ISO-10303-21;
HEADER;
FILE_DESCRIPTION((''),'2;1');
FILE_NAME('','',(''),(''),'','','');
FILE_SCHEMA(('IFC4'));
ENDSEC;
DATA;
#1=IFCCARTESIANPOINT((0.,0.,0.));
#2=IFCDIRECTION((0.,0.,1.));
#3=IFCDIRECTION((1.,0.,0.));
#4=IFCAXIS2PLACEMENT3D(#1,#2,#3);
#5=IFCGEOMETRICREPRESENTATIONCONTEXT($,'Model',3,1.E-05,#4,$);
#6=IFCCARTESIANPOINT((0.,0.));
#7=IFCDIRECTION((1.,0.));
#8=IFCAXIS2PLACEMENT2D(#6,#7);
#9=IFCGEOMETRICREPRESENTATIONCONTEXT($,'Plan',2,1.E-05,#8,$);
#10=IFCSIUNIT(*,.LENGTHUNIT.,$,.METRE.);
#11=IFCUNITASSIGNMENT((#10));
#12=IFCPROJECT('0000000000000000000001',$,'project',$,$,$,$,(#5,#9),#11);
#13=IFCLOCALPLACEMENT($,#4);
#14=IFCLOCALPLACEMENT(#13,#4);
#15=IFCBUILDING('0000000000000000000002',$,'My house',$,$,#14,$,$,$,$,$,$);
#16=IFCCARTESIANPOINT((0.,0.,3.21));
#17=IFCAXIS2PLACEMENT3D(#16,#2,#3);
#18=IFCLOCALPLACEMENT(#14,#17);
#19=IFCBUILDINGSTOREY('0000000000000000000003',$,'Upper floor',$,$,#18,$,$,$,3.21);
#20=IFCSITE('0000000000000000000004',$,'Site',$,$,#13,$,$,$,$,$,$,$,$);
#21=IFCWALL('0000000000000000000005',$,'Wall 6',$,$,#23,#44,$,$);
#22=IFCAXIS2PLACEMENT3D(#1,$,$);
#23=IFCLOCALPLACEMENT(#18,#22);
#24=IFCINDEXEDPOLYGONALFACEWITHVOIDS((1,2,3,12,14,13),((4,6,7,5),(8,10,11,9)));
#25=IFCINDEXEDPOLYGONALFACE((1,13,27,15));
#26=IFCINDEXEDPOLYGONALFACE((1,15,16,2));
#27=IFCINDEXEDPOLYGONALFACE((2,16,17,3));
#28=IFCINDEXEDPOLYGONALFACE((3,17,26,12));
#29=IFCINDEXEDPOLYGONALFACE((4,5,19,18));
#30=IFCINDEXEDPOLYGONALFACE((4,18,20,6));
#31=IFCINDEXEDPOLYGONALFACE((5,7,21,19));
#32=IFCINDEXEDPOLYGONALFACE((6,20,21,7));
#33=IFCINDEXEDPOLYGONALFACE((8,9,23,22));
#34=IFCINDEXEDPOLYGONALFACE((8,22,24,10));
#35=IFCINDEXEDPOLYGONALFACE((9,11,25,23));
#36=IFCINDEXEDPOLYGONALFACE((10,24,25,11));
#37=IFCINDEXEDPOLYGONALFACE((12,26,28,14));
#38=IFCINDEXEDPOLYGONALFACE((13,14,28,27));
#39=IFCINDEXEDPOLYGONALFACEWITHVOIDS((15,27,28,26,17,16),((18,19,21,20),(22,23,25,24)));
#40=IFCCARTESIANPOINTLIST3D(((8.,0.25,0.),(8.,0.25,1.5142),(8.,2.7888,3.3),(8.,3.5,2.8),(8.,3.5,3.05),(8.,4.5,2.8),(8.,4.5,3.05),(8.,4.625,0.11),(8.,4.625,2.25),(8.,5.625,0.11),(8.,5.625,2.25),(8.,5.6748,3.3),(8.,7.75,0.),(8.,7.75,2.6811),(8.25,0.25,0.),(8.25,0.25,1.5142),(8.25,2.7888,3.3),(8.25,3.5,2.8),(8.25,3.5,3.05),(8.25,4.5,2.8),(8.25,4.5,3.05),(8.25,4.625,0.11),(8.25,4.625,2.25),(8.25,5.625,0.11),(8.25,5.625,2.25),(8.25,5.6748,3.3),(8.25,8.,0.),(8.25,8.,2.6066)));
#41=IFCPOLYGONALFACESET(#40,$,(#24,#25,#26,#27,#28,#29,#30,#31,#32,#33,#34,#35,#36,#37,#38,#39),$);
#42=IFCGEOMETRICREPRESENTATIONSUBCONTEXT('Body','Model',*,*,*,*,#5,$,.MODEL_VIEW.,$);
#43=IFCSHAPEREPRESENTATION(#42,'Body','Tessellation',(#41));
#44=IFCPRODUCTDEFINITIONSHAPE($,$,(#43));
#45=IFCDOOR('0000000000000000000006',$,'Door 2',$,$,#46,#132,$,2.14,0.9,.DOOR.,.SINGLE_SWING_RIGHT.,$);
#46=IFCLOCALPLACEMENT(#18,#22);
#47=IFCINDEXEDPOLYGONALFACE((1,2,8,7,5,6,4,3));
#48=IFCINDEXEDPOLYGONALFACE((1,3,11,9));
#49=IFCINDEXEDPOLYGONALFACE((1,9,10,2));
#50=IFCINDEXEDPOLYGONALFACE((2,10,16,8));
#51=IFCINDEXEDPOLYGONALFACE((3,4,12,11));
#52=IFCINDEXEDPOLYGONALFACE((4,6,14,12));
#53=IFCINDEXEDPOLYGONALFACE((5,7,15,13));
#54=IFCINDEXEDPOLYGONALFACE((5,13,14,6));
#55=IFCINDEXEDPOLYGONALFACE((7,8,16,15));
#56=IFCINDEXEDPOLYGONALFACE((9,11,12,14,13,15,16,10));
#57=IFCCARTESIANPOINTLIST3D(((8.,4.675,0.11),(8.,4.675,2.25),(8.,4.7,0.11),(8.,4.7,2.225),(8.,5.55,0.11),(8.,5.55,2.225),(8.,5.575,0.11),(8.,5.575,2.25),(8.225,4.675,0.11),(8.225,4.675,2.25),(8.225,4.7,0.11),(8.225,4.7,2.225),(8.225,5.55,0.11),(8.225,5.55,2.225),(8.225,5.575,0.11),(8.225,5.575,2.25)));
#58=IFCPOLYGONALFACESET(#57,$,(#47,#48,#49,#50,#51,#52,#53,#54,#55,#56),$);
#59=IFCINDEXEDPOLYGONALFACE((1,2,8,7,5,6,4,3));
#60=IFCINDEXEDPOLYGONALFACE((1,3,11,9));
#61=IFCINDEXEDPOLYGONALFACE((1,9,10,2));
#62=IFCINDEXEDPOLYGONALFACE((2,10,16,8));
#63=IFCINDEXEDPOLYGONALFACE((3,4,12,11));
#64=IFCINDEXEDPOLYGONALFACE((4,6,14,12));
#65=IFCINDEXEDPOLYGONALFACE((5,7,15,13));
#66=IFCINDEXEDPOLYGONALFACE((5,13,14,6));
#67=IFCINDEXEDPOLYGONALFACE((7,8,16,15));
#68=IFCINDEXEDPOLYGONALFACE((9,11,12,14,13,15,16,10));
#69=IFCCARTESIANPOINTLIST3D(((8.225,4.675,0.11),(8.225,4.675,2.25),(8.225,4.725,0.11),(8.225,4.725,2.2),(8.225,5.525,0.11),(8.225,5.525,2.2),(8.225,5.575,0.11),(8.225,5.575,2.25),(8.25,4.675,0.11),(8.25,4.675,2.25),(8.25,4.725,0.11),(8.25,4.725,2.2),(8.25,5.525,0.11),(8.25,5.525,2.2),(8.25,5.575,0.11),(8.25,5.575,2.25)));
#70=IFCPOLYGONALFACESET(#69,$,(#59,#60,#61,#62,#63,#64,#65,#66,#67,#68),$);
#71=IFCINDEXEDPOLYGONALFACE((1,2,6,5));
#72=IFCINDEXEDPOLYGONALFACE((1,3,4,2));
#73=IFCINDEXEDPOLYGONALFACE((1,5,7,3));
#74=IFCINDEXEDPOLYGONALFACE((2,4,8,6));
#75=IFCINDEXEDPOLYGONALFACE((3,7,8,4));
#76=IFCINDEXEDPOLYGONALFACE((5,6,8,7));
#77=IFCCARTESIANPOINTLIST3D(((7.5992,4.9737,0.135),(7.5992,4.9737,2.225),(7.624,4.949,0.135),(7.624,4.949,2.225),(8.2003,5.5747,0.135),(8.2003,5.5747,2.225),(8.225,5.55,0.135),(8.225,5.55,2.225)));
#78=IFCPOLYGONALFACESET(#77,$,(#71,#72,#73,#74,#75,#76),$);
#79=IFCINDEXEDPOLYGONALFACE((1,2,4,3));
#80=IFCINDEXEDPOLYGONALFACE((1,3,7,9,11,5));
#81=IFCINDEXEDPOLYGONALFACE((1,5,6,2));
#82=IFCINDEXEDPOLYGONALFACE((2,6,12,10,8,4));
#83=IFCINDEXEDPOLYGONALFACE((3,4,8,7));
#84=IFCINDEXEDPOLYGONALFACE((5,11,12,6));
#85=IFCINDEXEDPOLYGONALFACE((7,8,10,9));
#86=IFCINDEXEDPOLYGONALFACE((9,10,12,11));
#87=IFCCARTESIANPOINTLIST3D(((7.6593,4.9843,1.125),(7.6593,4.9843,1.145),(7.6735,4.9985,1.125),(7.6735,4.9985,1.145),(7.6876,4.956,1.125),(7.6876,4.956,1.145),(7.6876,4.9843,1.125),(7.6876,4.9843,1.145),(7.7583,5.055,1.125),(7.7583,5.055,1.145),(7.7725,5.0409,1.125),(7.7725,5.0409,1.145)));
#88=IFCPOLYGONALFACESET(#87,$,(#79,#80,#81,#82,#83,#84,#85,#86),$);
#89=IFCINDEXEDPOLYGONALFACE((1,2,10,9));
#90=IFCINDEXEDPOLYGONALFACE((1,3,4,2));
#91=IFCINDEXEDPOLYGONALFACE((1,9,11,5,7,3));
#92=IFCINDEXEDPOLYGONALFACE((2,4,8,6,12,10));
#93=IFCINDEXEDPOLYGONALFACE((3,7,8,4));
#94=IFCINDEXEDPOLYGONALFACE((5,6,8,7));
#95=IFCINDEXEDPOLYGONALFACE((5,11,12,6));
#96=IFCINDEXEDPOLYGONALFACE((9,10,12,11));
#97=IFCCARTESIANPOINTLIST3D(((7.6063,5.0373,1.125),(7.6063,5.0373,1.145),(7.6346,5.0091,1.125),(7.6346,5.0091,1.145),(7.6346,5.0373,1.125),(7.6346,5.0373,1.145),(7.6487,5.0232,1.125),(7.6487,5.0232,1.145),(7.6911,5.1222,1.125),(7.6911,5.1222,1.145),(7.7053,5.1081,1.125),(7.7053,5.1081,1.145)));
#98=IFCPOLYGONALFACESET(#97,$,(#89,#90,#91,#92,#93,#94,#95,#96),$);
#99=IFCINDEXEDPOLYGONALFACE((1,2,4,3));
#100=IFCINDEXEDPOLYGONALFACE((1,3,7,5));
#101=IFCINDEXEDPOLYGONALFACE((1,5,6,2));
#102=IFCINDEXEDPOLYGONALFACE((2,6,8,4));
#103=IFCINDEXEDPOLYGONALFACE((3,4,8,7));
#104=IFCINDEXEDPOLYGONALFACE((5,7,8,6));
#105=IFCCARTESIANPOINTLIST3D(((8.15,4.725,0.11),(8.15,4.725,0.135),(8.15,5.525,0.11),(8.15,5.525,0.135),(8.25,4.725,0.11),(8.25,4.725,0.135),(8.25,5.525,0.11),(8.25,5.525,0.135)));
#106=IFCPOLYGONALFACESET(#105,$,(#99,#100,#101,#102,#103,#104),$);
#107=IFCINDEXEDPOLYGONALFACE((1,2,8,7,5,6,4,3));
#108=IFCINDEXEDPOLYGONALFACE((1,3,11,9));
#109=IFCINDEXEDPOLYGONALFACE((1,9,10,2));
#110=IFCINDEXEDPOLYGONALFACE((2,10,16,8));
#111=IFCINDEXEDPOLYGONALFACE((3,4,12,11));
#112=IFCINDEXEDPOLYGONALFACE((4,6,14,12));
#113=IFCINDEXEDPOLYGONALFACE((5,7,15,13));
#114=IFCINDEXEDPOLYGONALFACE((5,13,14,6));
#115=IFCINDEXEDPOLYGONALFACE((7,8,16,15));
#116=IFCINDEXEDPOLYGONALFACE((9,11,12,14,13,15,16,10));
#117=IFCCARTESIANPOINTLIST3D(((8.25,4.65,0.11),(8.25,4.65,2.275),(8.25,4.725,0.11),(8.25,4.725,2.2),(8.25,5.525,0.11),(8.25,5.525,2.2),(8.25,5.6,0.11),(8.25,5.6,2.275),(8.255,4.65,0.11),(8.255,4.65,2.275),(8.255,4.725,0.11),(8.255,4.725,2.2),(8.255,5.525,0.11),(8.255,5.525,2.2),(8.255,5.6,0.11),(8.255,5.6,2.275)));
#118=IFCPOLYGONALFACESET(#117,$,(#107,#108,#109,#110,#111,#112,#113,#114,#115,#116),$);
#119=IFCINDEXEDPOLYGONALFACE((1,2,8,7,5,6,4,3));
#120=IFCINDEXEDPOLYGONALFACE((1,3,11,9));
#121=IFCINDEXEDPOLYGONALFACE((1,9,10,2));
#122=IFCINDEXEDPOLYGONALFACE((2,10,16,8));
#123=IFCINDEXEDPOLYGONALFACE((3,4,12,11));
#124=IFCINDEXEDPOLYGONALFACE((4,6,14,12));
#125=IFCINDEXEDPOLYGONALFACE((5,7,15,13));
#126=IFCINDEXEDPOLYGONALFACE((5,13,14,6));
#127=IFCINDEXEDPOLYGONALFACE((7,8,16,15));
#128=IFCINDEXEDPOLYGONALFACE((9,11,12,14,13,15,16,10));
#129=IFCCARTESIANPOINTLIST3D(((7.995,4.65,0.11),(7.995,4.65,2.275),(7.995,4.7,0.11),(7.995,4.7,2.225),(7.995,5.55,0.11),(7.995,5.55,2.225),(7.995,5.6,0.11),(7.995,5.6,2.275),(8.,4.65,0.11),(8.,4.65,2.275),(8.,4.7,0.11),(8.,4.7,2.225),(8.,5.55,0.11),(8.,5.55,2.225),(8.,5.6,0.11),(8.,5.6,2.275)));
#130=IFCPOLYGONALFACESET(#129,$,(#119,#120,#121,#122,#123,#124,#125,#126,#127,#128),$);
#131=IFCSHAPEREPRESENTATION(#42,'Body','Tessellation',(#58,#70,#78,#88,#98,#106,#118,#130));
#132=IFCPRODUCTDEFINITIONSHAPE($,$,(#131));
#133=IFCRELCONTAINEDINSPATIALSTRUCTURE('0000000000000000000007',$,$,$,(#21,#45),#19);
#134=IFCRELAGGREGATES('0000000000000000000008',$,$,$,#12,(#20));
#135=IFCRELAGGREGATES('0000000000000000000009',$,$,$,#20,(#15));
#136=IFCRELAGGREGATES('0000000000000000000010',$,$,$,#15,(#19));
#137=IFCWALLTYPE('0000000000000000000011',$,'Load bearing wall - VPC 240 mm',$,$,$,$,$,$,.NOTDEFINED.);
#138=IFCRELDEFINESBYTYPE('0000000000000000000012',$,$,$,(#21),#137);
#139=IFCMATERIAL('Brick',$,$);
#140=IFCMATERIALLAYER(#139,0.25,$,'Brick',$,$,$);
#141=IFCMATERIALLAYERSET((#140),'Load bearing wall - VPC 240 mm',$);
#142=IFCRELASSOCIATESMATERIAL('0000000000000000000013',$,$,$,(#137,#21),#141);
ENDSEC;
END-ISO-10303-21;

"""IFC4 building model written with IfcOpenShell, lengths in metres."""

from ifc_helpers import new_model, entity, si_unit, frame, origin_with_axes, origin_2d_with_axis, place, context, subcontext, project, spatial, line, indexed_curve, outline, extrude, clip, halfspace, shape, material, layer, layer_set, layer_usage, type_object, element, fill, save


model = new_model("IFC4")

# Units and contexts
model_context = context("Model", 3, precision=1e-05, world=origin_with_axes())
plan_context = context("Plan", 2, precision=1e-05, world=origin_2d_with_axis())
body_context_1 = subcontext(model_context, "Body", "Model", "MODEL_VIEW")
body_context_2 = subcontext(plan_context, "Body", "Plan", "PLAN_VIEW")
ifc_project = project(units=[si_unit("LENGTHUNIT", "METRE")], contexts=[model_context, plan_context])

# Site, building, storey
site_placement = place(None, origin_with_axes())
site = spatial("IfcSite", under=ifc_project, at=site_placement, Name="Site")
building_placement = place(site_placement, origin_with_axes())
building = spatial("IfcBuilding", under=site, at=building_placement, Name="My house")
storey_placement = place(building_placement, frame((0.0, 0.0, 3.21), z_axis=(0.0, 0.0, 1.0), x_axis=(1.0, 0.0, 0.0)))
storey = spatial("IfcBuildingStorey", under=building, at=storey_placement, Name="Upper floor", Elevation=3.21)

# Shared definitions
ifc_material_1 = material(Name="Brick")
ifc_layer_1 = layer(ifc_material_1, 0.25, Name="Brick")
ifc_layer_set_1 = layer_set([ifc_layer_1], Name="Load bearing wall - VPC 240 mm")
wall_type_1 = type_object("IfcWallType", Name="Load bearing wall - VPC 240 mm", PredefinedType="NOTDEFINED", material=ifc_layer_set_1)

# Wall, openings, door
ifc_layer_usage_1 = layer_usage(ifc_layer_set_1, "AXIS2", "NEGATIVE", 0.25)
wall_1_placement = place(storey_placement, frame((8.25, 0.0, 0.0), z_axis=(0.0, 0.0, 1.0), x_axis=(0.0, 1.0, 0.0)))
wall_1 = element("IfcWall", 1, at=wall_1_placement, inside=storey, type_object=wall_type_1, material=ifc_layer_usage_1, Name="Wall 6", context=body_context_1, shape_type="Clipping", body=[
    clip(clip(clip(extrude(outline(indexed_curve([(0.25, 0.0), (0.25, 0.25), (7.75, 0.25), (8.0, 0.0)], segments=[line(1, 2, 3, 4, 1)])), origin_with_axes(), (0.0, 0.0, 1.0), 4.0), halfspace(frame((0.045, 8.25, 1.37), z_axis=(-0.575329, 0.0, 0.817922), x_axis=(0.0, 1.0, 0.0)), False)), halfspace(frame((7.955, 8.25, 2.62), z_axis=(0.28578, 0.0, 0.958295), x_axis=(0.0, -1.0, 0.0)), False)), halfspace(frame((3.13, 8.25, 3.3), z_axis=(0.0, 0.0, 1.0), x_axis=(-1.0, 0.0, 0.0)), False)),
])
opening_1_placement = place(wall_1_placement, frame((3.5, 0.0, 2.8), z_axis=(0.0, 0.0, 1.0), x_axis=(1.0, 0.0, 0.0)))
element("IfcOpeningElement", 2, at=opening_1_placement, cuts=wall_1, PredefinedType="OPENING", context=body_context_1, shape_type="SweptSolid", body=[
    extrude(outline(indexed_curve([(0.0, 0.0), (0.0, 0.35), (1.0, 0.35), (1.0, 0.0), (0.0, 0.0)], self_intersect=False)), frame((0.0, -0.05, 0.0), z_axis=(0.0, 0.0, 1.0), x_axis=(1.0, 0.0, 0.0)), (0.0, 0.0, 1.0), 0.25),
])
opening_2_placement = place(wall_1_placement, frame((4.625, 0.0, 0.11), z_axis=(0.0, 0.0, 1.0), x_axis=(1.0, 0.0, 0.0)))
opening_2 = element("IfcOpeningElement", 3, at=opening_2_placement, cuts=wall_1, PredefinedType="OPENING", context=body_context_1, shape_type="SweptSolid", body=[
    extrude(outline(indexed_curve([(0.0, 0.0), (0.0, 0.35), (1.0, 0.35), (1.0, 0.0), (0.0, 0.0)], self_intersect=False)), frame((0.0, -0.05, 0.0), z_axis=(0.0, 0.0, 1.0), x_axis=(1.0, 0.0, 0.0)), (0.0, 0.0, 1.0), 2.14),
])
door_1_placement = place(opening_2_placement, frame((0.05, 0.0, 0.0), z_axis=(0.0, 0.0, 1.0), x_axis=(1.0, 0.0, 0.0)))
door_1 = element("IfcDoor", 4, at=door_1_placement, inside=storey, Name="Door 2", OperationType="SINGLE_SWING_RIGHT", OverallHeight=2.14, OverallWidth=0.9, PredefinedType="DOOR", shapes=[
    shape(body_context_1, "Body", "SweptSolid", [extrude(outline(indexed_curve([(0.0, 0.0), (0.0, 2.14), (0.9, 2.14), (0.9, 0.0), (0.875, 0.0), (0.875, 2.115), (0.025, 2.115), (0.025, 0.0)], segments=[line(1, 2, 3, 4, 5, 6, 7, 8, 1)])), frame((0.0, 0.025, 0.0), z_axis=(0.0, -1.0, 0.0), x_axis=(1.0, 0.0, 0.0)), (0.0, 0.0, -1.0), 0.225), extrude(outline(indexed_curve([(0.0, 0.0), (0.0, 2.14), (0.9, 2.14), (0.9, 0.0), (0.85, 0.0), (0.85, 2.09), (0.05, 2.09), (0.05, 0.0)], segments=[line(1, 2, 3, 4, 5, 6, 7, 8, 1)])), frame((0.0, 0.0, 0.0), z_axis=(0.0, -1.0, 0.0), x_axis=(1.0, 0.0, 0.0)), (0.0, 0.0, -1.0), 0.025), extrude(outline(indexed_curve([(0.0, 0.0), (0.85, 0.0), (0.85, 0.035), (0.0, 0.035)], segments=[line(1, 2, 3, 4, 1)])), frame((0.274, 0.626, 0.025), z_axis=(0.0, 0.0, 1.0), x_axis=(0.707107, -0.707107, 0.0)), (0.0, 0.0, 1.0), 2.09), extrude(outline(indexed_curve([(0.0, 0.0), (0.0, -0.04), (0.12, -0.04), (0.12, -0.02), (0.02, -0.02), (0.02, 0.0)], segments=[line(1, 2, 3, 4, 5, 6, 1)])), frame((0.3093, 0.5907, 1.015), z_axis=(0.0, 0.0, 1.0), x_axis=(0.707107, -0.707107, 0.0)), (0.0, 0.0, 1.0), 0.02), extrude(outline(indexed_curve([(0.0, 0.0), (0.0, 0.04), (0.12, 0.04), (0.12, 0.02), (0.02, 0.02), (0.02, 0.0)], segments=[line(1, 2, 3, 4, 5, 6, 1)])), frame((0.3341, 0.6154, 1.015), z_axis=(0.0, 0.0, 1.0), x_axis=(0.707107, -0.707107, 0.0)), (0.0, 0.0, 1.0), 0.02), extrude(outline(indexed_curve([(0.0, 0.0), (0.8, 0.0), (0.8, 0.1), (0.0, 0.1)], segments=[line(1, 2, 3, 4, 1)])), frame((0.05, 0.0, 0.0), z_axis=(0.0, 0.0, 1.0), x_axis=(1.0, 0.0, 0.0)), (0.0, 0.0, 1.0), 0.025), extrude(outline(indexed_curve([(0.0, 0.0), (0.0, 2.165), (0.95, 2.165), (0.95, 0.0), (0.875, 0.0), (0.875, 2.09), (0.075, 2.09), (0.075, 0.0)], segments=[line(1, 2, 3, 4, 5, 6, 7, 8, 1)])), frame((-0.025, -0.005, 0.0), z_axis=(0.0, -1.0, 0.0), x_axis=(1.0, 0.0, 0.0)), (0.0, 0.0, -1.0), 0.005), extrude(outline(indexed_curve([(0.0, 0.0), (0.0, 2.165), (0.95, 2.165), (0.95, 0.0), (0.9, 0.0), (0.9, 2.115), (0.05, 2.115), (0.05, 0.0)], segments=[line(1, 2, 3, 4, 5, 6, 7, 8, 1)])), frame((-0.025, 0.25, 0.0), z_axis=(0.0, -1.0, 0.0), x_axis=(1.0, 0.0, 0.0)), (0.0, 0.0, -1.0), 0.005)]),
    shape(body_context_2, "Body", "Curve2D", [entity("IfcIndexedPolyCurve", entity("IfcCartesianPointList2D", [[0.0, 0.0], [0.0, 0.25], [0.025, 0.25], [0.025, 0.025], [0.05, 0.025], [0.05, 0.0]]), [entity("IfcLineIndex", [1, 2, 3, 4, 5, 6, 1])]), entity("IfcIndexedPolyCurve", entity("IfcCartesianPointList2D", [[0.9, 0.0], [0.9, 0.25], [0.875, 0.25], [0.875, 0.025], [0.85, 0.025], [0.85, 0.0]]), [entity("IfcLineIndex", [1, 2, 3, 4, 5, 6, 1])]), entity("IfcTrimmedCurve", entity("IfcEllipse", entity("IfcAxis2Placement2D", entity("IfcCartesianPoint", [0.84, 0.25]), entity("IfcDirection", [1.0, 0.0])), 0.815, 0.85), [entity("IfcCartesianPoint", [0.84, 1.1])], [entity("IfcCartesianPoint", [0.025, 0.25])], True, "CARTESIAN"), entity("IfcIndexedPolyCurve", entity("IfcCartesianPointList2D", [[0.875, 0.25], [0.84, 0.25], [0.84, 1.1], [0.875, 1.1]]), [entity("IfcLineIndex", [1, 2, 3, 4, 1])])]),
])
fill(opening_2, door_1)

save(model, "model.ifc")
